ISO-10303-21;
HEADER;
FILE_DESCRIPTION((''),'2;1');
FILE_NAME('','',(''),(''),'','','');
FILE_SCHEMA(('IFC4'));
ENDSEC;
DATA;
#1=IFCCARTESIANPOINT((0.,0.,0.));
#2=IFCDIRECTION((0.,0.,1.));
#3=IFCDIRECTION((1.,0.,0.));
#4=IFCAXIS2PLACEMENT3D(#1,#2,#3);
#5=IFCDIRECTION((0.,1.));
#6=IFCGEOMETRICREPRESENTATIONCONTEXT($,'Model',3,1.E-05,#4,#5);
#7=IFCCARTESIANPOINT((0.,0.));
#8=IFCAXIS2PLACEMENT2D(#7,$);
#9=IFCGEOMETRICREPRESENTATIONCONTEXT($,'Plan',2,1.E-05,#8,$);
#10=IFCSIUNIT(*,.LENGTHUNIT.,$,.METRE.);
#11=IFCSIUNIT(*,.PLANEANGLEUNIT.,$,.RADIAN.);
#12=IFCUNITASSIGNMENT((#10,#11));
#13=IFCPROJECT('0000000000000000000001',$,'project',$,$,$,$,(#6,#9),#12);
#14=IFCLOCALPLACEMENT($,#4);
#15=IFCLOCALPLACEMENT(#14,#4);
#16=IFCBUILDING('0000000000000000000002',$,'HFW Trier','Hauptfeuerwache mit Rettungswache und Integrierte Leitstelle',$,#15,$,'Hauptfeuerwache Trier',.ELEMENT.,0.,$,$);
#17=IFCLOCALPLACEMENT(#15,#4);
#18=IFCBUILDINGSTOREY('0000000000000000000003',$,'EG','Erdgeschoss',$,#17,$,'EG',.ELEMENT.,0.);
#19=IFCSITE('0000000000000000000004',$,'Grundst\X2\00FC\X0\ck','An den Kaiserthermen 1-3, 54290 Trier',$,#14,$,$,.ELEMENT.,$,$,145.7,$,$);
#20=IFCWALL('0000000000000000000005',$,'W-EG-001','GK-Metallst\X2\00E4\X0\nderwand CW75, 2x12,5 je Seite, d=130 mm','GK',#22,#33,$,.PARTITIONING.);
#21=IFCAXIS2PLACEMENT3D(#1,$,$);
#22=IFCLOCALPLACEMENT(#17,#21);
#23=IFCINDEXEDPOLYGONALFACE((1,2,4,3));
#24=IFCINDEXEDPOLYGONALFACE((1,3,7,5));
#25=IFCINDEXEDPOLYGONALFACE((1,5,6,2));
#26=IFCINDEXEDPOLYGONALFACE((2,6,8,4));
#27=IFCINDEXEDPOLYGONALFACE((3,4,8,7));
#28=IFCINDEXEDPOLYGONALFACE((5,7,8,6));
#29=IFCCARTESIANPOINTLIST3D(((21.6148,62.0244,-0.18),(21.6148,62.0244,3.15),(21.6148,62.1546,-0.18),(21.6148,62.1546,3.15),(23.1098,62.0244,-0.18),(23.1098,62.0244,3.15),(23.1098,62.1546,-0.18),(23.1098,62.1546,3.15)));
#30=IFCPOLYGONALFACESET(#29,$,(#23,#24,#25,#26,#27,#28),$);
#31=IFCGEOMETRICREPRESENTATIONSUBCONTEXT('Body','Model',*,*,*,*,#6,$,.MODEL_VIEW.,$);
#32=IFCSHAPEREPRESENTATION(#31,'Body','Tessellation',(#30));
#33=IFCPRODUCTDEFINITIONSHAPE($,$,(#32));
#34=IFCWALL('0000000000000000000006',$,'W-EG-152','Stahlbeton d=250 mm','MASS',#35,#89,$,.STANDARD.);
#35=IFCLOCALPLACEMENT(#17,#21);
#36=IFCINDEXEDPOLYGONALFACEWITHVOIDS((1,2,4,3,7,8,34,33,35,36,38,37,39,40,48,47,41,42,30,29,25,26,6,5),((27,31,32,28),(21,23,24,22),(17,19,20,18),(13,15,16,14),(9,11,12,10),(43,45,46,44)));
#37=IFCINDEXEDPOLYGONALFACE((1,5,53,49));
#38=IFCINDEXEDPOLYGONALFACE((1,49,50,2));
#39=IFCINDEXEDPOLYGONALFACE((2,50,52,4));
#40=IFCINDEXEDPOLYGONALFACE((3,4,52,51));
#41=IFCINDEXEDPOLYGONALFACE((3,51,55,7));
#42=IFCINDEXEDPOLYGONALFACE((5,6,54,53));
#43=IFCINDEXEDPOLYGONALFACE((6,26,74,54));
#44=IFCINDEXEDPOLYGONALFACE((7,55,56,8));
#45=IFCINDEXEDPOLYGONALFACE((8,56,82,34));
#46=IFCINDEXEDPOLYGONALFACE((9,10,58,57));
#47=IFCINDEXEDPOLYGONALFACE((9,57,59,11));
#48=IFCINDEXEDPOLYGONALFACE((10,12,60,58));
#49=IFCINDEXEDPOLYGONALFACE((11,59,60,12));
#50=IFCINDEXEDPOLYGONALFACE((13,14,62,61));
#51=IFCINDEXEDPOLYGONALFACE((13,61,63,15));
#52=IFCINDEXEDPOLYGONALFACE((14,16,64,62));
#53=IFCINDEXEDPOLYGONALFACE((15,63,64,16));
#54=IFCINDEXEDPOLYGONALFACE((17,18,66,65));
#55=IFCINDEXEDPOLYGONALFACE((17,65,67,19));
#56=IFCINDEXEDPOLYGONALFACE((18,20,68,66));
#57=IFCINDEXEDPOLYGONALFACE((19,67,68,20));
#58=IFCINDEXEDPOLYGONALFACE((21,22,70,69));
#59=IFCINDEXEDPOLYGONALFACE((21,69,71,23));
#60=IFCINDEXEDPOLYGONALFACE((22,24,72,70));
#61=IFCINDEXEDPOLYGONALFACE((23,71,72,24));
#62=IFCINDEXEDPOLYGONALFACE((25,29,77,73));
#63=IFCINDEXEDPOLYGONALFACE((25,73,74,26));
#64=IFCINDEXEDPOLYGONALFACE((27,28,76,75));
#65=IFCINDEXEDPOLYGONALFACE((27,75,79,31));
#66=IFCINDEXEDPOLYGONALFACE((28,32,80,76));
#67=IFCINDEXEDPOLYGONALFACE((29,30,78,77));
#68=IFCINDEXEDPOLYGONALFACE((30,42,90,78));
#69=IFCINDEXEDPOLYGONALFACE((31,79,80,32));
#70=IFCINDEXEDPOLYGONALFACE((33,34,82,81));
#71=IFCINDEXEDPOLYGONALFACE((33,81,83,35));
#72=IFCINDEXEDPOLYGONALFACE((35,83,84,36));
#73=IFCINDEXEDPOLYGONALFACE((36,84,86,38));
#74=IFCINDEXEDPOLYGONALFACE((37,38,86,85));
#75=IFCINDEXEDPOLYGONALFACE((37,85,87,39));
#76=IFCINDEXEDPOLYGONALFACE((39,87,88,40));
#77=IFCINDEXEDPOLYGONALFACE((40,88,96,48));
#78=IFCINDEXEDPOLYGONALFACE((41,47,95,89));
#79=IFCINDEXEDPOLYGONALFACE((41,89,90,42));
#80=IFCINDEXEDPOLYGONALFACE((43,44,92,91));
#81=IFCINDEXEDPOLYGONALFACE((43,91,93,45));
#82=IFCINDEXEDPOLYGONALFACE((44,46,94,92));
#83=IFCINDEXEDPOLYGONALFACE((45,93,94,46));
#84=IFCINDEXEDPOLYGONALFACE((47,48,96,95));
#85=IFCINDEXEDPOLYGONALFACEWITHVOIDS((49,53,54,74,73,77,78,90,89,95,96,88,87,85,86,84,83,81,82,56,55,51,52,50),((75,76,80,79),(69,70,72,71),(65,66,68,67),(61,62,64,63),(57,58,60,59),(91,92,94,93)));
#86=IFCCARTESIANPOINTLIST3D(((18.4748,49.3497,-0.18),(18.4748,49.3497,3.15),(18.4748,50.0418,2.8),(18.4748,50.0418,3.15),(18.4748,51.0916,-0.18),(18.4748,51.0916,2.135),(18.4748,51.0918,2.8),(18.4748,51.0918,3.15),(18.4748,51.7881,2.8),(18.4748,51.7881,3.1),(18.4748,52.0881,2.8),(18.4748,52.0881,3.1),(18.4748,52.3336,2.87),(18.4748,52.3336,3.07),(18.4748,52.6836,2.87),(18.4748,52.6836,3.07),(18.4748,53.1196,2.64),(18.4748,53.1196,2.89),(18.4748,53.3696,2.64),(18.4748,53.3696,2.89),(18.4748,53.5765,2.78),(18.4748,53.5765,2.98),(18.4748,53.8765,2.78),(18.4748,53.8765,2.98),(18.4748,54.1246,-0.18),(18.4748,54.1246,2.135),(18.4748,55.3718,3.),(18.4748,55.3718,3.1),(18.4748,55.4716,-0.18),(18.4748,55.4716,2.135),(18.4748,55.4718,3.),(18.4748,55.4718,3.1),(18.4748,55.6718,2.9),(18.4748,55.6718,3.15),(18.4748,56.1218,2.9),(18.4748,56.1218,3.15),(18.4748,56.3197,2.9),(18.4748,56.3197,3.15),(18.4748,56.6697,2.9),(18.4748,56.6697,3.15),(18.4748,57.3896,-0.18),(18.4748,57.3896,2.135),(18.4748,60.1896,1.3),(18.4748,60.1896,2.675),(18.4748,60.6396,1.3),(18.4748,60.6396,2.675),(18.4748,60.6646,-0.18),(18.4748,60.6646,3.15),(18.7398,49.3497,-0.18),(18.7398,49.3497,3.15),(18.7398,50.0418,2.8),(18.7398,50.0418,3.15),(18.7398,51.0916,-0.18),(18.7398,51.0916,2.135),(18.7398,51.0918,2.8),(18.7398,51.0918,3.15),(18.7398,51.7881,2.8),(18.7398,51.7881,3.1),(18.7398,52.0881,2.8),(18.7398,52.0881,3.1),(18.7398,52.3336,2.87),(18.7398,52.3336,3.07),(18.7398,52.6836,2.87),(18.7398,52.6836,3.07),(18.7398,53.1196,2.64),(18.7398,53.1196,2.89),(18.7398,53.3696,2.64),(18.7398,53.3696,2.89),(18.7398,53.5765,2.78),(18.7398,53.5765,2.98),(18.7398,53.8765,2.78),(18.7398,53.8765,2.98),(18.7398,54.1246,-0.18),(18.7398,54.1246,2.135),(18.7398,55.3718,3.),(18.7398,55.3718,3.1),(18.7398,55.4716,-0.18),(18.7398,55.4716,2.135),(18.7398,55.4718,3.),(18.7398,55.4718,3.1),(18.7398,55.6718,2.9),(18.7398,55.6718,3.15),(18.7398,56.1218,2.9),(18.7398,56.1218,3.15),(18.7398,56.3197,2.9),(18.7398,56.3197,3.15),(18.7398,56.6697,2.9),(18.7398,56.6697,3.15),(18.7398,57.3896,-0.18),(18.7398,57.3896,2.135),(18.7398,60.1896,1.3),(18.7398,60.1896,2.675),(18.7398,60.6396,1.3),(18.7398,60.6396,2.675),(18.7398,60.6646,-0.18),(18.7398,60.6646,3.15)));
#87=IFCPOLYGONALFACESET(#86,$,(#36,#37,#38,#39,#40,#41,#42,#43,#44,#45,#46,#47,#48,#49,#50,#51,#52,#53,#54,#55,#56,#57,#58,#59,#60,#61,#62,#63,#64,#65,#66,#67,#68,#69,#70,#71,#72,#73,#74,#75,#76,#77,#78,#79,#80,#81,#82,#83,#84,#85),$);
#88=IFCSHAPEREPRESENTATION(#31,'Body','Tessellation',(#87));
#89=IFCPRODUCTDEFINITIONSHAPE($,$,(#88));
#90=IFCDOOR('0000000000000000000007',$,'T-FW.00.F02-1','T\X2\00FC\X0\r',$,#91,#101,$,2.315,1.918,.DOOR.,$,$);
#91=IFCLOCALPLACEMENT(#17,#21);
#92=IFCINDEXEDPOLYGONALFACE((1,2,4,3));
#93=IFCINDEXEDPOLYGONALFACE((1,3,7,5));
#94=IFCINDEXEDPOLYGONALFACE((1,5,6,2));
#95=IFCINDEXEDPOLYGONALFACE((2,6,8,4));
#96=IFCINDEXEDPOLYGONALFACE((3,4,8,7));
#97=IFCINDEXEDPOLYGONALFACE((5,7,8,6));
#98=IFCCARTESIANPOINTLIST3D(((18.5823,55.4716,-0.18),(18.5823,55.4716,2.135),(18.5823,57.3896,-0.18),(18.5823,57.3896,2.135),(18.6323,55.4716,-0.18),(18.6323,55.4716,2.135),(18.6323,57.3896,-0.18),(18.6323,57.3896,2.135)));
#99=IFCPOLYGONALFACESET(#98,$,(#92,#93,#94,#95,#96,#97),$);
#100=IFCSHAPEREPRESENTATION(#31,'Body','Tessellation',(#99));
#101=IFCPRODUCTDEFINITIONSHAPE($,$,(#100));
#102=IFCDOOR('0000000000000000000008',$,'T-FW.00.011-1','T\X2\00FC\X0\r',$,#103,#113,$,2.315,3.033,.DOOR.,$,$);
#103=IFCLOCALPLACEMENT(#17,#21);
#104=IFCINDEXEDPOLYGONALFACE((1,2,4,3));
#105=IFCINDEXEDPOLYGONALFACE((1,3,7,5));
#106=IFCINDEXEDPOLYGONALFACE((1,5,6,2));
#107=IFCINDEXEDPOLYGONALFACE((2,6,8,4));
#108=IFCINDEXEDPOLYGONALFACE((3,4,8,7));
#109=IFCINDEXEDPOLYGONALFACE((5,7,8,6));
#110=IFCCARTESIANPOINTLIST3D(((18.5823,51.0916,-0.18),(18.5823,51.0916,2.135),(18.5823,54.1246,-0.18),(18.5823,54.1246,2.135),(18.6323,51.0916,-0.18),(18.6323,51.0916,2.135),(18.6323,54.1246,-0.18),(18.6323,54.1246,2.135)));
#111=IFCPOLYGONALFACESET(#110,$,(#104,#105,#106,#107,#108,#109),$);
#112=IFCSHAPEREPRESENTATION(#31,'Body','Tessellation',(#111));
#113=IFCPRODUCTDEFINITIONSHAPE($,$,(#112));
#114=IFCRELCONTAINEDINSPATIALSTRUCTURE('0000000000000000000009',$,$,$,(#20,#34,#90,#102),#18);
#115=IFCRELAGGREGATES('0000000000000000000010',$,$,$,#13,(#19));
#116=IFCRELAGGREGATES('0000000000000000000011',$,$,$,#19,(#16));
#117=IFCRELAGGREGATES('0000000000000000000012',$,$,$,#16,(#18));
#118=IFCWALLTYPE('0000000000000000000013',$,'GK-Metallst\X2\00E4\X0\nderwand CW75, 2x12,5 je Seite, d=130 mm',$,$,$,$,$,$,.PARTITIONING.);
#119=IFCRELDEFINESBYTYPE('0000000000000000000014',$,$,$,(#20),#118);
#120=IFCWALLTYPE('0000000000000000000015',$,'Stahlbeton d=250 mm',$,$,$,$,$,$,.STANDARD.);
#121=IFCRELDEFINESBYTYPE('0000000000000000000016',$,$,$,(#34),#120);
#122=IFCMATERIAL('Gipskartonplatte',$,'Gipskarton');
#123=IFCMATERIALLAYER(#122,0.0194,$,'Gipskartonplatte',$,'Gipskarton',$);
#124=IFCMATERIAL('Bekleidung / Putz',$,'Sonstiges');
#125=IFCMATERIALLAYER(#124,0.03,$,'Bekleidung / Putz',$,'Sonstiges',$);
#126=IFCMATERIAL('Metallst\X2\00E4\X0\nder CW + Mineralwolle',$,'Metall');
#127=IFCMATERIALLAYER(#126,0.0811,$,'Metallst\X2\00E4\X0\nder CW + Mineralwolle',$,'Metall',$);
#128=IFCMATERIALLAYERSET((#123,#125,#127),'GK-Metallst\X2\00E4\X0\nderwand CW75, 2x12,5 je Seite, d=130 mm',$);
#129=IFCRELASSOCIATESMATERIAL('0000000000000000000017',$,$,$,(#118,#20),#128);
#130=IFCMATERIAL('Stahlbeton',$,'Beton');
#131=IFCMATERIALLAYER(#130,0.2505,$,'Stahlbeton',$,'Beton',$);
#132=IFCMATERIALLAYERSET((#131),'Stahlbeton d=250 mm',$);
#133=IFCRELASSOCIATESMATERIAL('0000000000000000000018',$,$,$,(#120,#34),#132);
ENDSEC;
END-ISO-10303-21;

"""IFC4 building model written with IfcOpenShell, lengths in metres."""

from ifc_helpers import new_model, si_unit, direction, frame, frame_2d, origin_with_axes, origin_2d, place, context, subcontext, project, spatial, rectangle, extrude, material, layer, layer_set, layer_usage, type_object, element, fill, save


model = new_model("IFC4")

# Units and contexts
model_context = context("Model", 3, precision=1e-05, world=origin_with_axes(), true_north=direction((0.0, 1.0)))
plan_context = context("Plan", 2, precision=1e-05, world=origin_2d())
body_context = subcontext(model_context, "Body", "Model", "MODEL_VIEW")
ifc_project = project(units=[si_unit("LENGTHUNIT", "METRE"), si_unit("PLANEANGLEUNIT", "RADIAN")], contexts=[model_context, plan_context])

# Site, building, storey
site_placement = place(None, origin_with_axes())
site = spatial("IfcSite", under=ifc_project, at=site_placement, Name="Grundstück", Description="An den Kaiserthermen 1-3, 54290 Trier", CompositionType="ELEMENT", RefElevation=145.7)
building_placement = place(site_placement, origin_with_axes())
building = spatial("IfcBuilding", under=site, at=building_placement, Name="HFW Trier", Description="Hauptfeuerwache mit Rettungswache und Integrierte Leitstelle", LongName="Hauptfeuerwache Trier", CompositionType="ELEMENT", ElevationOfRefHeight=0.0)
storey_placement = place(building_placement, origin_with_axes())
storey = spatial("IfcBuildingStorey", under=building, at=storey_placement, Name="EG", Description="Erdgeschoss", LongName="EG", CompositionType="ELEMENT", Elevation=0.0)

# Wall
ifc_material_1 = material(Name="Gipskartonplatte", Category="Gipskarton")
ifc_layer_1 = layer(ifc_material_1, 0.0194, Name="Gipskartonplatte", Category="Gipskarton")
ifc_material_2 = material(Name="Bekleidung / Putz", Category="Sonstiges")
ifc_layer_2 = layer(ifc_material_2, 0.03, Name="Bekleidung / Putz", Category="Sonstiges")
ifc_material_3 = material(Name="Metallständer CW + Mineralwolle", Category="Metall")
ifc_layer_3 = layer(ifc_material_3, 0.0811, Name="Metallständer CW + Mineralwolle", Category="Metall")
ifc_layer_set_1 = layer_set([ifc_layer_1, ifc_layer_2, ifc_layer_3], Name="GK-Metallständerwand CW75, 2x12,5 je Seite, d=130 mm")
ifc_layer_usage_1 = layer_usage(ifc_layer_set_1, "AXIS2", "POSITIVE", -0.065)
wall_type_1 = type_object("IfcWallType", Name="GK-Metallständerwand CW75, 2x12,5 je Seite, d=130 mm", PredefinedType="PARTITIONING", material=ifc_layer_set_1)
wall_1_placement = place(storey_placement, frame((21.6148, 62.0895, -0.18), z_axis=(0.0, 0.0, 1.0), x_axis=(1.0, 0.0, 0.0)))
element("IfcWall", 1, at=wall_1_placement, inside=storey, type_object=wall_type_1, material=ifc_layer_usage_1, Name="W-EG-001", Description="GK-Metallständerwand CW75, 2x12,5 je Seite, d=130 mm", ObjectType="GK", PredefinedType="PARTITIONING", context=body_context, shape_type="SweptSolid", body=[
    extrude(rectangle(XDim=1.495, YDim=0.1301, at=frame_2d((0.7475, 0.0))), origin_with_axes(), (0.0, 0.0, 1.0), 3.33),
])

# Wall, openings, doors
ifc_material_4 = material(Name="Stahlbeton", Category="Beton")
ifc_layer_4 = layer(ifc_material_4, 0.2505, Name="Stahlbeton", Category="Beton")
ifc_layer_set_2 = layer_set([ifc_layer_4], Name="Stahlbeton d=250 mm")
ifc_layer_usage_2 = layer_usage(ifc_layer_set_2, "AXIS2", "POSITIVE", -0.1325)
wall_type_2 = type_object("IfcWallType", Name="Stahlbeton d=250 mm", PredefinedType="STANDARD", material=ifc_layer_set_2)
wall_2_placement = place(storey_placement, frame((18.6073, 60.6646, -0.18), z_axis=(0.0, 0.0, 1.0), x_axis=(0.0, -1.0, 0.0)))
wall_2 = element("IfcWall", 2, at=wall_2_placement, inside=storey, type_object=wall_type_2, material=ifc_layer_usage_2, Name="W-EG-152", Description="Stahlbeton d=250 mm", ObjectType="MASS", PredefinedType="STANDARD", context=body_context, shape_type="SweptSolid", body=[
    extrude(rectangle(XDim=11.3149, YDim=0.265, at=frame_2d((5.6575, 0.0))), origin_with_axes(), (0.0, 0.0, 1.0), 3.33),
])
opening_1_placement = place(wall_2_placement, frame((3.275, 0.0, 0.0), z_axis=(0.0, 0.0, 1.0), x_axis=(1.0, 0.0, 0.0)))
opening_1 = element("IfcOpeningElement", 3, at=opening_1_placement, cuts=wall_2, PredefinedType="OPENING", context=body_context, shape_type="SweptSolid", body=[
    extrude(rectangle(XDim=1.918, YDim=0.365, at=frame_2d((0.959, 0.0))), origin_with_axes(), (0.0, 0.0, 1.0), 2.315),
])
opening_2_placement = place(wall_2_placement, frame((6.54, 0.0, 0.0), z_axis=(0.0, 0.0, 1.0), x_axis=(1.0, 0.0, 0.0)))
opening_2 = element("IfcOpeningElement", 4, at=opening_2_placement, cuts=wall_2, PredefinedType="OPENING", context=body_context, shape_type="SweptSolid", body=[
    extrude(rectangle(XDim=3.033, YDim=0.365, at=frame_2d((1.5165, 0.0))), origin_with_axes(), (0.0, 0.0, 1.0), 2.315),
])
opening_3_placement = place(wall_2_placement, origin_with_axes())
element("IfcOpeningElement", 5, at=opening_3_placement, cuts=wall_2, ObjectType="Wanddurchbruch", PredefinedType="OPENING", context=body_context, shape_type="SweptSolid", body=[
    extrude(rectangle(XDim=0.45, YDim=0.365, at=frame_2d((4.7678, 0.0))), frame((0.0, 0.0, 3.08), z_axis=(0.0, 0.0, 1.0), x_axis=(1.0, 0.0, 0.0)), (0.0, 0.0, 1.0), 0.25),
])
opening_4_placement = place(wall_2_placement, origin_with_axes())
element("IfcOpeningElement", 6, at=opening_4_placement, cuts=wall_2, ObjectType="Wanddurchbruch", PredefinedType="OPENING", context=body_context, shape_type="SweptSolid", body=[
    extrude(rectangle(XDim=0.35, YDim=0.365, at=frame_2d((4.1699, 0.0))), frame((0.0, 0.0, 3.08), z_axis=(0.0, 0.0, 1.0), x_axis=(1.0, 0.0, 0.0)), (0.0, 0.0, 1.0), 0.25),
])
opening_5_placement = place(wall_2_placement, origin_with_axes())
element("IfcOpeningElement", 7, at=opening_5_placement, cuts=wall_2, ObjectType="Wanddurchbruch", PredefinedType="OPENING", context=body_context, shape_type="SweptSolid", body=[
    extrude(rectangle(XDim=0.1, YDim=0.365, at=frame_2d((5.2428, 0.0))), frame((0.0, 0.0, 3.18), z_axis=(0.0, 0.0, 1.0), x_axis=(1.0, 0.0, 0.0)), (0.0, 0.0, 1.0), 0.1),
])
opening_6_placement = place(wall_2_placement, origin_with_axes())
element("IfcOpeningElement", 8, at=opening_6_placement, cuts=wall_2, ObjectType="Wanddurchbruch", PredefinedType="OPENING", context=body_context, shape_type="SweptSolid", body=[
    extrude(rectangle(XDim=0.3, YDim=0.365, at=frame_2d((6.9381, 0.0))), frame((0.0, 0.0, 2.96), z_axis=(0.0, 0.0, 1.0), x_axis=(1.0, 0.0, 0.0)), (0.0, 0.0, 1.0), 0.2),
])
opening_7_placement = place(wall_2_placement, origin_with_axes())
element("IfcOpeningElement", 9, at=opening_7_placement, cuts=wall_2, ObjectType="Wanddurchbruch", PredefinedType="OPENING", context=body_context, shape_type="SweptSolid", body=[
    extrude(rectangle(XDim=0.25, YDim=0.365, at=frame_2d((7.42, 0.0))), frame((0.0, 0.0, 2.82), z_axis=(0.0, 0.0, 1.0), x_axis=(1.0, 0.0, 0.0)), (0.0, 0.0, 1.0), 0.25),
])
opening_8_placement = place(wall_2_placement, origin_with_axes())
element("IfcOpeningElement", 10, at=opening_8_placement, cuts=wall_2, ObjectType="Wanddurchbruch", PredefinedType="OPENING", context=body_context, shape_type="SweptSolid", body=[
    extrude(rectangle(XDim=0.35, YDim=0.365, at=frame_2d((8.156, 0.0))), frame((0.0, 0.0, 3.05), z_axis=(0.0, 0.0, 1.0), x_axis=(1.0, 0.0, 0.0)), (0.0, 0.0, 1.0), 0.2),
])
opening_9_placement = place(wall_2_placement, origin_with_axes())
element("IfcOpeningElement", 11, at=opening_9_placement, cuts=wall_2, ObjectType="Wanddurchbruch", PredefinedType="OPENING", context=body_context, shape_type="SweptSolid", body=[
    extrude(rectangle(XDim=0.3, YDim=0.365, at=frame_2d((8.7265, 0.0))), frame((0.0, 0.0, 2.98), z_axis=(0.0, 0.0, 1.0), x_axis=(1.0, 0.0, 0.0)), (0.0, 0.0, 1.0), 0.3),
])
opening_10_placement = place(wall_2_placement, origin_with_axes())
element("IfcOpeningElement", 12, at=opening_10_placement, cuts=wall_2, ObjectType="Wanddurchbruch", PredefinedType="OPENING", context=body_context, shape_type="SweptSolid", body=[
    extrude(rectangle(XDim=1.05, YDim=0.365, at=frame_2d((10.0978, 0.0))), frame((0.0, 0.0, 2.98), z_axis=(0.0, 0.0, 1.0), x_axis=(1.0, 0.0, 0.0)), (0.0, 0.0, 1.0), 0.35),
])
opening_11_placement = place(wall_2_placement, origin_with_axes())
element("IfcOpeningElement", 13, at=opening_11_placement, cuts=wall_2, ObjectType="Wanddurchbruch", PredefinedType="OPENING", context=body_context, shape_type="SweptSolid", body=[
    extrude(rectangle(XDim=0.45, YDim=0.365, at=frame_2d((0.25, 0.0))), frame((0.0, 0.0, 1.48), z_axis=(0.0, 0.0, 1.0), x_axis=(1.0, 0.0, 0.0)), (0.0, 0.0, 1.0), 1.375),
])
door_1_placement = place(wall_2_placement, frame((3.275, 0.0, 0.0), z_axis=(0.0, 0.0, 1.0), x_axis=(1.0, 0.0, 0.0)))
door_1 = element("IfcDoor", 14, at=door_1_placement, inside=storey, Name="T-FW.00.F02-1", Description="Tür", OverallHeight=2.315, OverallWidth=1.918, PredefinedType="DOOR", context=body_context, shape_type="SweptSolid", body=[
    extrude(rectangle(XDim=1.918, YDim=0.05, at=frame_2d((0.959, 0.0))), origin_with_axes(), (0.0, 0.0, 1.0), 2.315),
])
fill(opening_1, door_1)
door_2_placement = place(wall_2_placement, frame((6.54, 0.0, 0.0), z_axis=(0.0, 0.0, 1.0), x_axis=(1.0, 0.0, 0.0)))
door_2 = element("IfcDoor", 15, at=door_2_placement, inside=storey, Name="T-FW.00.011-1", Description="Tür", OverallHeight=2.315, OverallWidth=3.033, PredefinedType="DOOR", context=body_context, shape_type="SweptSolid", body=[
    extrude(rectangle(XDim=3.033, YDim=0.05, at=frame_2d((1.5165, 0.0))), origin_with_axes(), (0.0, 0.0, 1.0), 2.315),
])
fill(opening_2, door_2)

save(model, "model.ifc")
